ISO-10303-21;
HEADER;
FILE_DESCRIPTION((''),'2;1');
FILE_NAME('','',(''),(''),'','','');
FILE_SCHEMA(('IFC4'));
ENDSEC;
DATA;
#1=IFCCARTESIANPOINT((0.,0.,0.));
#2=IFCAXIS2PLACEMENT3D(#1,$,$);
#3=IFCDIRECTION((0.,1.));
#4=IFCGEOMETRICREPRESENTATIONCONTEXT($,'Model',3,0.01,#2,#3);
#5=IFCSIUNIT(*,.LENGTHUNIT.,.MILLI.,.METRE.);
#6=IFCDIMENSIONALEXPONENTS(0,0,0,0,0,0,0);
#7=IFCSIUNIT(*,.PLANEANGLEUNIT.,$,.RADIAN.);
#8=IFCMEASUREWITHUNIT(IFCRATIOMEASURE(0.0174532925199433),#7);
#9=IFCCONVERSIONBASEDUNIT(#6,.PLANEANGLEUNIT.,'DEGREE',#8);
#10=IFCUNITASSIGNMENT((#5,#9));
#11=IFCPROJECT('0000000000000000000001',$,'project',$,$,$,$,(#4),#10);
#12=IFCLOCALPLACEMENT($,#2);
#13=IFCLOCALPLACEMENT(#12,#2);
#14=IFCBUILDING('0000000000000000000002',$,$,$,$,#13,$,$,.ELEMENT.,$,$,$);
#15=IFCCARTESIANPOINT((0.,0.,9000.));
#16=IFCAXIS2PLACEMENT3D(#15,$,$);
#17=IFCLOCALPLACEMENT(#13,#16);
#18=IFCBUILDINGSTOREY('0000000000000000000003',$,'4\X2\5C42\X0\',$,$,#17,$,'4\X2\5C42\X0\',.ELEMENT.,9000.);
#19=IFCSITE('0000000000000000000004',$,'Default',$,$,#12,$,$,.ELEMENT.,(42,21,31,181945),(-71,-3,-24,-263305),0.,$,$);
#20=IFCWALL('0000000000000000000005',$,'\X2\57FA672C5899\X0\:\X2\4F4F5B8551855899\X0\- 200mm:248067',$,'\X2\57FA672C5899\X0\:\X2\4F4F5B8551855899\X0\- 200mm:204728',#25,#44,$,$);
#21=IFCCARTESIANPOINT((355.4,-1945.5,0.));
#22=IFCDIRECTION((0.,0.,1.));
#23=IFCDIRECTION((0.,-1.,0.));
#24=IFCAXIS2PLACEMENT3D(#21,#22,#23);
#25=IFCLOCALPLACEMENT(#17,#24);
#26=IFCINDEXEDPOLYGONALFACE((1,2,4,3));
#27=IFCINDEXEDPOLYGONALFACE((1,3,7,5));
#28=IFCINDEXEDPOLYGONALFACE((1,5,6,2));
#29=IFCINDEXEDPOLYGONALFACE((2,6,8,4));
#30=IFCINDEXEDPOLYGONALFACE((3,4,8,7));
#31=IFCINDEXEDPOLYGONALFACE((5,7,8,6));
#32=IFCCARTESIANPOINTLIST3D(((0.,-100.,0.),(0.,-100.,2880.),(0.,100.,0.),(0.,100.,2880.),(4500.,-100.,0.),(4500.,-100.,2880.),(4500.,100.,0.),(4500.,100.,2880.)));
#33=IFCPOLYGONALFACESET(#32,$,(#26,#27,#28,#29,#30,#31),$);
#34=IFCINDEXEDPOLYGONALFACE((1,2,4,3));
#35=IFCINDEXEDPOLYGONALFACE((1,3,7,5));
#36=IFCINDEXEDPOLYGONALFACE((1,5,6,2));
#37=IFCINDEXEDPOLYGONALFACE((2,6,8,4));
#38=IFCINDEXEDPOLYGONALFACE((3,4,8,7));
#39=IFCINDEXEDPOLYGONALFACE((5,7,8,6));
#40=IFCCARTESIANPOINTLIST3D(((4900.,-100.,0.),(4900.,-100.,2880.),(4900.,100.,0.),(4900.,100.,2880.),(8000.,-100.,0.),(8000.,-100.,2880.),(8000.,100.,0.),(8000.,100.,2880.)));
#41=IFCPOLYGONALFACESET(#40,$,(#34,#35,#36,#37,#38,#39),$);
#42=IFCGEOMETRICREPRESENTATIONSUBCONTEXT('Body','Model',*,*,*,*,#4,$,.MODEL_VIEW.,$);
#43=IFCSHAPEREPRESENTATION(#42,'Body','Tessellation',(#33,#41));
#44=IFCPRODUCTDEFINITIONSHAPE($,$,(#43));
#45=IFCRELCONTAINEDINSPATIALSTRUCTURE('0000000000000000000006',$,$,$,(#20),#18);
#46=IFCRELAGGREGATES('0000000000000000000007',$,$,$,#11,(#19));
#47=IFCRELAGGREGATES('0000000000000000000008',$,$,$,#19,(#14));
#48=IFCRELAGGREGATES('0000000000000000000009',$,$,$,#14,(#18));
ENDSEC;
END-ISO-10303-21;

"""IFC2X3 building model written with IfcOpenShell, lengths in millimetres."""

from ifc_helpers import new_model, entity, si_unit, converted_unit, direction, frame, frame_2d, origin, place, context, subcontext, project, spatial, rectangle, extrude, element, save


model = new_model("IFC2X3")

# Units and contexts
model_context = context("Model", 3, precision=0.01, world=origin(), true_north=direction((0.0, 1.0)))
body_context = subcontext(model_context, "Body", "Model", "MODEL_VIEW")
ifc_project = project(units=[si_unit("LENGTHUNIT", "METRE", prefix="MILLI"), converted_unit("PLANEANGLEUNIT", "DEGREE", entity("IfcRatioMeasure", 0.0174532925199433), si_unit("PLANEANGLEUNIT", "RADIAN"), dimensions=[0, 0, 0, 0, 0, 0, 0])], contexts=[model_context])

# Site, building, storey
site_placement = place(None, origin())
site = spatial("IfcSite", under=ifc_project, at=site_placement, Name="Default", CompositionType="ELEMENT", RefLatitude=(42, 21, 31, 181945), RefLongitude=(-71, -3, -24, -263305), RefElevation=0.0)
building_placement = place(site_placement, origin())
building = spatial("IfcBuilding", under=site, at=building_placement, CompositionType="ELEMENT")
storey_placement = place(building_placement, frame((0.0, 0.0, 9000.0)))
storey = spatial("IfcBuildingStorey", under=building, at=storey_placement, Name="4层", LongName="4层", CompositionType="ELEMENT", Elevation=9000.0)

# Wall
wall_1_placement = place(storey_placement, frame((355.4, -1945.5, 0.0), z_axis=(0.0, 0.0, 1.0), x_axis=(0.0, -1.0, 0.0)))
element("IfcWall", 1, at=wall_1_placement, inside=storey, Name="基本墙:住宅内墙- 200mm:248067", ObjectType="基本墙:住宅内墙- 200mm:204728", context=body_context, shape_type="SweptSolid", body=[
    extrude(rectangle(XDim=4500.0, YDim=200.0, at=frame_2d((-675.0, 0.0), x_axis=(1.0, 0.0))), frame((2925.0, 0.0, 0.0)), (0.0, 0.0, 1.0), 2880.0),
    extrude(rectangle(XDim=3100.0, YDim=200.0, at=frame_2d((0.0, 0.0), x_axis=(1.0, 0.0))), frame((6450.0, 0.0, 0.0), z_axis=(0.0, 0.0, 1.0), x_axis=(-1.0, 0.0, 0.0)), (0.0, 0.0, 1.0), 2880.0),
])

save(model, "model.ifc")
